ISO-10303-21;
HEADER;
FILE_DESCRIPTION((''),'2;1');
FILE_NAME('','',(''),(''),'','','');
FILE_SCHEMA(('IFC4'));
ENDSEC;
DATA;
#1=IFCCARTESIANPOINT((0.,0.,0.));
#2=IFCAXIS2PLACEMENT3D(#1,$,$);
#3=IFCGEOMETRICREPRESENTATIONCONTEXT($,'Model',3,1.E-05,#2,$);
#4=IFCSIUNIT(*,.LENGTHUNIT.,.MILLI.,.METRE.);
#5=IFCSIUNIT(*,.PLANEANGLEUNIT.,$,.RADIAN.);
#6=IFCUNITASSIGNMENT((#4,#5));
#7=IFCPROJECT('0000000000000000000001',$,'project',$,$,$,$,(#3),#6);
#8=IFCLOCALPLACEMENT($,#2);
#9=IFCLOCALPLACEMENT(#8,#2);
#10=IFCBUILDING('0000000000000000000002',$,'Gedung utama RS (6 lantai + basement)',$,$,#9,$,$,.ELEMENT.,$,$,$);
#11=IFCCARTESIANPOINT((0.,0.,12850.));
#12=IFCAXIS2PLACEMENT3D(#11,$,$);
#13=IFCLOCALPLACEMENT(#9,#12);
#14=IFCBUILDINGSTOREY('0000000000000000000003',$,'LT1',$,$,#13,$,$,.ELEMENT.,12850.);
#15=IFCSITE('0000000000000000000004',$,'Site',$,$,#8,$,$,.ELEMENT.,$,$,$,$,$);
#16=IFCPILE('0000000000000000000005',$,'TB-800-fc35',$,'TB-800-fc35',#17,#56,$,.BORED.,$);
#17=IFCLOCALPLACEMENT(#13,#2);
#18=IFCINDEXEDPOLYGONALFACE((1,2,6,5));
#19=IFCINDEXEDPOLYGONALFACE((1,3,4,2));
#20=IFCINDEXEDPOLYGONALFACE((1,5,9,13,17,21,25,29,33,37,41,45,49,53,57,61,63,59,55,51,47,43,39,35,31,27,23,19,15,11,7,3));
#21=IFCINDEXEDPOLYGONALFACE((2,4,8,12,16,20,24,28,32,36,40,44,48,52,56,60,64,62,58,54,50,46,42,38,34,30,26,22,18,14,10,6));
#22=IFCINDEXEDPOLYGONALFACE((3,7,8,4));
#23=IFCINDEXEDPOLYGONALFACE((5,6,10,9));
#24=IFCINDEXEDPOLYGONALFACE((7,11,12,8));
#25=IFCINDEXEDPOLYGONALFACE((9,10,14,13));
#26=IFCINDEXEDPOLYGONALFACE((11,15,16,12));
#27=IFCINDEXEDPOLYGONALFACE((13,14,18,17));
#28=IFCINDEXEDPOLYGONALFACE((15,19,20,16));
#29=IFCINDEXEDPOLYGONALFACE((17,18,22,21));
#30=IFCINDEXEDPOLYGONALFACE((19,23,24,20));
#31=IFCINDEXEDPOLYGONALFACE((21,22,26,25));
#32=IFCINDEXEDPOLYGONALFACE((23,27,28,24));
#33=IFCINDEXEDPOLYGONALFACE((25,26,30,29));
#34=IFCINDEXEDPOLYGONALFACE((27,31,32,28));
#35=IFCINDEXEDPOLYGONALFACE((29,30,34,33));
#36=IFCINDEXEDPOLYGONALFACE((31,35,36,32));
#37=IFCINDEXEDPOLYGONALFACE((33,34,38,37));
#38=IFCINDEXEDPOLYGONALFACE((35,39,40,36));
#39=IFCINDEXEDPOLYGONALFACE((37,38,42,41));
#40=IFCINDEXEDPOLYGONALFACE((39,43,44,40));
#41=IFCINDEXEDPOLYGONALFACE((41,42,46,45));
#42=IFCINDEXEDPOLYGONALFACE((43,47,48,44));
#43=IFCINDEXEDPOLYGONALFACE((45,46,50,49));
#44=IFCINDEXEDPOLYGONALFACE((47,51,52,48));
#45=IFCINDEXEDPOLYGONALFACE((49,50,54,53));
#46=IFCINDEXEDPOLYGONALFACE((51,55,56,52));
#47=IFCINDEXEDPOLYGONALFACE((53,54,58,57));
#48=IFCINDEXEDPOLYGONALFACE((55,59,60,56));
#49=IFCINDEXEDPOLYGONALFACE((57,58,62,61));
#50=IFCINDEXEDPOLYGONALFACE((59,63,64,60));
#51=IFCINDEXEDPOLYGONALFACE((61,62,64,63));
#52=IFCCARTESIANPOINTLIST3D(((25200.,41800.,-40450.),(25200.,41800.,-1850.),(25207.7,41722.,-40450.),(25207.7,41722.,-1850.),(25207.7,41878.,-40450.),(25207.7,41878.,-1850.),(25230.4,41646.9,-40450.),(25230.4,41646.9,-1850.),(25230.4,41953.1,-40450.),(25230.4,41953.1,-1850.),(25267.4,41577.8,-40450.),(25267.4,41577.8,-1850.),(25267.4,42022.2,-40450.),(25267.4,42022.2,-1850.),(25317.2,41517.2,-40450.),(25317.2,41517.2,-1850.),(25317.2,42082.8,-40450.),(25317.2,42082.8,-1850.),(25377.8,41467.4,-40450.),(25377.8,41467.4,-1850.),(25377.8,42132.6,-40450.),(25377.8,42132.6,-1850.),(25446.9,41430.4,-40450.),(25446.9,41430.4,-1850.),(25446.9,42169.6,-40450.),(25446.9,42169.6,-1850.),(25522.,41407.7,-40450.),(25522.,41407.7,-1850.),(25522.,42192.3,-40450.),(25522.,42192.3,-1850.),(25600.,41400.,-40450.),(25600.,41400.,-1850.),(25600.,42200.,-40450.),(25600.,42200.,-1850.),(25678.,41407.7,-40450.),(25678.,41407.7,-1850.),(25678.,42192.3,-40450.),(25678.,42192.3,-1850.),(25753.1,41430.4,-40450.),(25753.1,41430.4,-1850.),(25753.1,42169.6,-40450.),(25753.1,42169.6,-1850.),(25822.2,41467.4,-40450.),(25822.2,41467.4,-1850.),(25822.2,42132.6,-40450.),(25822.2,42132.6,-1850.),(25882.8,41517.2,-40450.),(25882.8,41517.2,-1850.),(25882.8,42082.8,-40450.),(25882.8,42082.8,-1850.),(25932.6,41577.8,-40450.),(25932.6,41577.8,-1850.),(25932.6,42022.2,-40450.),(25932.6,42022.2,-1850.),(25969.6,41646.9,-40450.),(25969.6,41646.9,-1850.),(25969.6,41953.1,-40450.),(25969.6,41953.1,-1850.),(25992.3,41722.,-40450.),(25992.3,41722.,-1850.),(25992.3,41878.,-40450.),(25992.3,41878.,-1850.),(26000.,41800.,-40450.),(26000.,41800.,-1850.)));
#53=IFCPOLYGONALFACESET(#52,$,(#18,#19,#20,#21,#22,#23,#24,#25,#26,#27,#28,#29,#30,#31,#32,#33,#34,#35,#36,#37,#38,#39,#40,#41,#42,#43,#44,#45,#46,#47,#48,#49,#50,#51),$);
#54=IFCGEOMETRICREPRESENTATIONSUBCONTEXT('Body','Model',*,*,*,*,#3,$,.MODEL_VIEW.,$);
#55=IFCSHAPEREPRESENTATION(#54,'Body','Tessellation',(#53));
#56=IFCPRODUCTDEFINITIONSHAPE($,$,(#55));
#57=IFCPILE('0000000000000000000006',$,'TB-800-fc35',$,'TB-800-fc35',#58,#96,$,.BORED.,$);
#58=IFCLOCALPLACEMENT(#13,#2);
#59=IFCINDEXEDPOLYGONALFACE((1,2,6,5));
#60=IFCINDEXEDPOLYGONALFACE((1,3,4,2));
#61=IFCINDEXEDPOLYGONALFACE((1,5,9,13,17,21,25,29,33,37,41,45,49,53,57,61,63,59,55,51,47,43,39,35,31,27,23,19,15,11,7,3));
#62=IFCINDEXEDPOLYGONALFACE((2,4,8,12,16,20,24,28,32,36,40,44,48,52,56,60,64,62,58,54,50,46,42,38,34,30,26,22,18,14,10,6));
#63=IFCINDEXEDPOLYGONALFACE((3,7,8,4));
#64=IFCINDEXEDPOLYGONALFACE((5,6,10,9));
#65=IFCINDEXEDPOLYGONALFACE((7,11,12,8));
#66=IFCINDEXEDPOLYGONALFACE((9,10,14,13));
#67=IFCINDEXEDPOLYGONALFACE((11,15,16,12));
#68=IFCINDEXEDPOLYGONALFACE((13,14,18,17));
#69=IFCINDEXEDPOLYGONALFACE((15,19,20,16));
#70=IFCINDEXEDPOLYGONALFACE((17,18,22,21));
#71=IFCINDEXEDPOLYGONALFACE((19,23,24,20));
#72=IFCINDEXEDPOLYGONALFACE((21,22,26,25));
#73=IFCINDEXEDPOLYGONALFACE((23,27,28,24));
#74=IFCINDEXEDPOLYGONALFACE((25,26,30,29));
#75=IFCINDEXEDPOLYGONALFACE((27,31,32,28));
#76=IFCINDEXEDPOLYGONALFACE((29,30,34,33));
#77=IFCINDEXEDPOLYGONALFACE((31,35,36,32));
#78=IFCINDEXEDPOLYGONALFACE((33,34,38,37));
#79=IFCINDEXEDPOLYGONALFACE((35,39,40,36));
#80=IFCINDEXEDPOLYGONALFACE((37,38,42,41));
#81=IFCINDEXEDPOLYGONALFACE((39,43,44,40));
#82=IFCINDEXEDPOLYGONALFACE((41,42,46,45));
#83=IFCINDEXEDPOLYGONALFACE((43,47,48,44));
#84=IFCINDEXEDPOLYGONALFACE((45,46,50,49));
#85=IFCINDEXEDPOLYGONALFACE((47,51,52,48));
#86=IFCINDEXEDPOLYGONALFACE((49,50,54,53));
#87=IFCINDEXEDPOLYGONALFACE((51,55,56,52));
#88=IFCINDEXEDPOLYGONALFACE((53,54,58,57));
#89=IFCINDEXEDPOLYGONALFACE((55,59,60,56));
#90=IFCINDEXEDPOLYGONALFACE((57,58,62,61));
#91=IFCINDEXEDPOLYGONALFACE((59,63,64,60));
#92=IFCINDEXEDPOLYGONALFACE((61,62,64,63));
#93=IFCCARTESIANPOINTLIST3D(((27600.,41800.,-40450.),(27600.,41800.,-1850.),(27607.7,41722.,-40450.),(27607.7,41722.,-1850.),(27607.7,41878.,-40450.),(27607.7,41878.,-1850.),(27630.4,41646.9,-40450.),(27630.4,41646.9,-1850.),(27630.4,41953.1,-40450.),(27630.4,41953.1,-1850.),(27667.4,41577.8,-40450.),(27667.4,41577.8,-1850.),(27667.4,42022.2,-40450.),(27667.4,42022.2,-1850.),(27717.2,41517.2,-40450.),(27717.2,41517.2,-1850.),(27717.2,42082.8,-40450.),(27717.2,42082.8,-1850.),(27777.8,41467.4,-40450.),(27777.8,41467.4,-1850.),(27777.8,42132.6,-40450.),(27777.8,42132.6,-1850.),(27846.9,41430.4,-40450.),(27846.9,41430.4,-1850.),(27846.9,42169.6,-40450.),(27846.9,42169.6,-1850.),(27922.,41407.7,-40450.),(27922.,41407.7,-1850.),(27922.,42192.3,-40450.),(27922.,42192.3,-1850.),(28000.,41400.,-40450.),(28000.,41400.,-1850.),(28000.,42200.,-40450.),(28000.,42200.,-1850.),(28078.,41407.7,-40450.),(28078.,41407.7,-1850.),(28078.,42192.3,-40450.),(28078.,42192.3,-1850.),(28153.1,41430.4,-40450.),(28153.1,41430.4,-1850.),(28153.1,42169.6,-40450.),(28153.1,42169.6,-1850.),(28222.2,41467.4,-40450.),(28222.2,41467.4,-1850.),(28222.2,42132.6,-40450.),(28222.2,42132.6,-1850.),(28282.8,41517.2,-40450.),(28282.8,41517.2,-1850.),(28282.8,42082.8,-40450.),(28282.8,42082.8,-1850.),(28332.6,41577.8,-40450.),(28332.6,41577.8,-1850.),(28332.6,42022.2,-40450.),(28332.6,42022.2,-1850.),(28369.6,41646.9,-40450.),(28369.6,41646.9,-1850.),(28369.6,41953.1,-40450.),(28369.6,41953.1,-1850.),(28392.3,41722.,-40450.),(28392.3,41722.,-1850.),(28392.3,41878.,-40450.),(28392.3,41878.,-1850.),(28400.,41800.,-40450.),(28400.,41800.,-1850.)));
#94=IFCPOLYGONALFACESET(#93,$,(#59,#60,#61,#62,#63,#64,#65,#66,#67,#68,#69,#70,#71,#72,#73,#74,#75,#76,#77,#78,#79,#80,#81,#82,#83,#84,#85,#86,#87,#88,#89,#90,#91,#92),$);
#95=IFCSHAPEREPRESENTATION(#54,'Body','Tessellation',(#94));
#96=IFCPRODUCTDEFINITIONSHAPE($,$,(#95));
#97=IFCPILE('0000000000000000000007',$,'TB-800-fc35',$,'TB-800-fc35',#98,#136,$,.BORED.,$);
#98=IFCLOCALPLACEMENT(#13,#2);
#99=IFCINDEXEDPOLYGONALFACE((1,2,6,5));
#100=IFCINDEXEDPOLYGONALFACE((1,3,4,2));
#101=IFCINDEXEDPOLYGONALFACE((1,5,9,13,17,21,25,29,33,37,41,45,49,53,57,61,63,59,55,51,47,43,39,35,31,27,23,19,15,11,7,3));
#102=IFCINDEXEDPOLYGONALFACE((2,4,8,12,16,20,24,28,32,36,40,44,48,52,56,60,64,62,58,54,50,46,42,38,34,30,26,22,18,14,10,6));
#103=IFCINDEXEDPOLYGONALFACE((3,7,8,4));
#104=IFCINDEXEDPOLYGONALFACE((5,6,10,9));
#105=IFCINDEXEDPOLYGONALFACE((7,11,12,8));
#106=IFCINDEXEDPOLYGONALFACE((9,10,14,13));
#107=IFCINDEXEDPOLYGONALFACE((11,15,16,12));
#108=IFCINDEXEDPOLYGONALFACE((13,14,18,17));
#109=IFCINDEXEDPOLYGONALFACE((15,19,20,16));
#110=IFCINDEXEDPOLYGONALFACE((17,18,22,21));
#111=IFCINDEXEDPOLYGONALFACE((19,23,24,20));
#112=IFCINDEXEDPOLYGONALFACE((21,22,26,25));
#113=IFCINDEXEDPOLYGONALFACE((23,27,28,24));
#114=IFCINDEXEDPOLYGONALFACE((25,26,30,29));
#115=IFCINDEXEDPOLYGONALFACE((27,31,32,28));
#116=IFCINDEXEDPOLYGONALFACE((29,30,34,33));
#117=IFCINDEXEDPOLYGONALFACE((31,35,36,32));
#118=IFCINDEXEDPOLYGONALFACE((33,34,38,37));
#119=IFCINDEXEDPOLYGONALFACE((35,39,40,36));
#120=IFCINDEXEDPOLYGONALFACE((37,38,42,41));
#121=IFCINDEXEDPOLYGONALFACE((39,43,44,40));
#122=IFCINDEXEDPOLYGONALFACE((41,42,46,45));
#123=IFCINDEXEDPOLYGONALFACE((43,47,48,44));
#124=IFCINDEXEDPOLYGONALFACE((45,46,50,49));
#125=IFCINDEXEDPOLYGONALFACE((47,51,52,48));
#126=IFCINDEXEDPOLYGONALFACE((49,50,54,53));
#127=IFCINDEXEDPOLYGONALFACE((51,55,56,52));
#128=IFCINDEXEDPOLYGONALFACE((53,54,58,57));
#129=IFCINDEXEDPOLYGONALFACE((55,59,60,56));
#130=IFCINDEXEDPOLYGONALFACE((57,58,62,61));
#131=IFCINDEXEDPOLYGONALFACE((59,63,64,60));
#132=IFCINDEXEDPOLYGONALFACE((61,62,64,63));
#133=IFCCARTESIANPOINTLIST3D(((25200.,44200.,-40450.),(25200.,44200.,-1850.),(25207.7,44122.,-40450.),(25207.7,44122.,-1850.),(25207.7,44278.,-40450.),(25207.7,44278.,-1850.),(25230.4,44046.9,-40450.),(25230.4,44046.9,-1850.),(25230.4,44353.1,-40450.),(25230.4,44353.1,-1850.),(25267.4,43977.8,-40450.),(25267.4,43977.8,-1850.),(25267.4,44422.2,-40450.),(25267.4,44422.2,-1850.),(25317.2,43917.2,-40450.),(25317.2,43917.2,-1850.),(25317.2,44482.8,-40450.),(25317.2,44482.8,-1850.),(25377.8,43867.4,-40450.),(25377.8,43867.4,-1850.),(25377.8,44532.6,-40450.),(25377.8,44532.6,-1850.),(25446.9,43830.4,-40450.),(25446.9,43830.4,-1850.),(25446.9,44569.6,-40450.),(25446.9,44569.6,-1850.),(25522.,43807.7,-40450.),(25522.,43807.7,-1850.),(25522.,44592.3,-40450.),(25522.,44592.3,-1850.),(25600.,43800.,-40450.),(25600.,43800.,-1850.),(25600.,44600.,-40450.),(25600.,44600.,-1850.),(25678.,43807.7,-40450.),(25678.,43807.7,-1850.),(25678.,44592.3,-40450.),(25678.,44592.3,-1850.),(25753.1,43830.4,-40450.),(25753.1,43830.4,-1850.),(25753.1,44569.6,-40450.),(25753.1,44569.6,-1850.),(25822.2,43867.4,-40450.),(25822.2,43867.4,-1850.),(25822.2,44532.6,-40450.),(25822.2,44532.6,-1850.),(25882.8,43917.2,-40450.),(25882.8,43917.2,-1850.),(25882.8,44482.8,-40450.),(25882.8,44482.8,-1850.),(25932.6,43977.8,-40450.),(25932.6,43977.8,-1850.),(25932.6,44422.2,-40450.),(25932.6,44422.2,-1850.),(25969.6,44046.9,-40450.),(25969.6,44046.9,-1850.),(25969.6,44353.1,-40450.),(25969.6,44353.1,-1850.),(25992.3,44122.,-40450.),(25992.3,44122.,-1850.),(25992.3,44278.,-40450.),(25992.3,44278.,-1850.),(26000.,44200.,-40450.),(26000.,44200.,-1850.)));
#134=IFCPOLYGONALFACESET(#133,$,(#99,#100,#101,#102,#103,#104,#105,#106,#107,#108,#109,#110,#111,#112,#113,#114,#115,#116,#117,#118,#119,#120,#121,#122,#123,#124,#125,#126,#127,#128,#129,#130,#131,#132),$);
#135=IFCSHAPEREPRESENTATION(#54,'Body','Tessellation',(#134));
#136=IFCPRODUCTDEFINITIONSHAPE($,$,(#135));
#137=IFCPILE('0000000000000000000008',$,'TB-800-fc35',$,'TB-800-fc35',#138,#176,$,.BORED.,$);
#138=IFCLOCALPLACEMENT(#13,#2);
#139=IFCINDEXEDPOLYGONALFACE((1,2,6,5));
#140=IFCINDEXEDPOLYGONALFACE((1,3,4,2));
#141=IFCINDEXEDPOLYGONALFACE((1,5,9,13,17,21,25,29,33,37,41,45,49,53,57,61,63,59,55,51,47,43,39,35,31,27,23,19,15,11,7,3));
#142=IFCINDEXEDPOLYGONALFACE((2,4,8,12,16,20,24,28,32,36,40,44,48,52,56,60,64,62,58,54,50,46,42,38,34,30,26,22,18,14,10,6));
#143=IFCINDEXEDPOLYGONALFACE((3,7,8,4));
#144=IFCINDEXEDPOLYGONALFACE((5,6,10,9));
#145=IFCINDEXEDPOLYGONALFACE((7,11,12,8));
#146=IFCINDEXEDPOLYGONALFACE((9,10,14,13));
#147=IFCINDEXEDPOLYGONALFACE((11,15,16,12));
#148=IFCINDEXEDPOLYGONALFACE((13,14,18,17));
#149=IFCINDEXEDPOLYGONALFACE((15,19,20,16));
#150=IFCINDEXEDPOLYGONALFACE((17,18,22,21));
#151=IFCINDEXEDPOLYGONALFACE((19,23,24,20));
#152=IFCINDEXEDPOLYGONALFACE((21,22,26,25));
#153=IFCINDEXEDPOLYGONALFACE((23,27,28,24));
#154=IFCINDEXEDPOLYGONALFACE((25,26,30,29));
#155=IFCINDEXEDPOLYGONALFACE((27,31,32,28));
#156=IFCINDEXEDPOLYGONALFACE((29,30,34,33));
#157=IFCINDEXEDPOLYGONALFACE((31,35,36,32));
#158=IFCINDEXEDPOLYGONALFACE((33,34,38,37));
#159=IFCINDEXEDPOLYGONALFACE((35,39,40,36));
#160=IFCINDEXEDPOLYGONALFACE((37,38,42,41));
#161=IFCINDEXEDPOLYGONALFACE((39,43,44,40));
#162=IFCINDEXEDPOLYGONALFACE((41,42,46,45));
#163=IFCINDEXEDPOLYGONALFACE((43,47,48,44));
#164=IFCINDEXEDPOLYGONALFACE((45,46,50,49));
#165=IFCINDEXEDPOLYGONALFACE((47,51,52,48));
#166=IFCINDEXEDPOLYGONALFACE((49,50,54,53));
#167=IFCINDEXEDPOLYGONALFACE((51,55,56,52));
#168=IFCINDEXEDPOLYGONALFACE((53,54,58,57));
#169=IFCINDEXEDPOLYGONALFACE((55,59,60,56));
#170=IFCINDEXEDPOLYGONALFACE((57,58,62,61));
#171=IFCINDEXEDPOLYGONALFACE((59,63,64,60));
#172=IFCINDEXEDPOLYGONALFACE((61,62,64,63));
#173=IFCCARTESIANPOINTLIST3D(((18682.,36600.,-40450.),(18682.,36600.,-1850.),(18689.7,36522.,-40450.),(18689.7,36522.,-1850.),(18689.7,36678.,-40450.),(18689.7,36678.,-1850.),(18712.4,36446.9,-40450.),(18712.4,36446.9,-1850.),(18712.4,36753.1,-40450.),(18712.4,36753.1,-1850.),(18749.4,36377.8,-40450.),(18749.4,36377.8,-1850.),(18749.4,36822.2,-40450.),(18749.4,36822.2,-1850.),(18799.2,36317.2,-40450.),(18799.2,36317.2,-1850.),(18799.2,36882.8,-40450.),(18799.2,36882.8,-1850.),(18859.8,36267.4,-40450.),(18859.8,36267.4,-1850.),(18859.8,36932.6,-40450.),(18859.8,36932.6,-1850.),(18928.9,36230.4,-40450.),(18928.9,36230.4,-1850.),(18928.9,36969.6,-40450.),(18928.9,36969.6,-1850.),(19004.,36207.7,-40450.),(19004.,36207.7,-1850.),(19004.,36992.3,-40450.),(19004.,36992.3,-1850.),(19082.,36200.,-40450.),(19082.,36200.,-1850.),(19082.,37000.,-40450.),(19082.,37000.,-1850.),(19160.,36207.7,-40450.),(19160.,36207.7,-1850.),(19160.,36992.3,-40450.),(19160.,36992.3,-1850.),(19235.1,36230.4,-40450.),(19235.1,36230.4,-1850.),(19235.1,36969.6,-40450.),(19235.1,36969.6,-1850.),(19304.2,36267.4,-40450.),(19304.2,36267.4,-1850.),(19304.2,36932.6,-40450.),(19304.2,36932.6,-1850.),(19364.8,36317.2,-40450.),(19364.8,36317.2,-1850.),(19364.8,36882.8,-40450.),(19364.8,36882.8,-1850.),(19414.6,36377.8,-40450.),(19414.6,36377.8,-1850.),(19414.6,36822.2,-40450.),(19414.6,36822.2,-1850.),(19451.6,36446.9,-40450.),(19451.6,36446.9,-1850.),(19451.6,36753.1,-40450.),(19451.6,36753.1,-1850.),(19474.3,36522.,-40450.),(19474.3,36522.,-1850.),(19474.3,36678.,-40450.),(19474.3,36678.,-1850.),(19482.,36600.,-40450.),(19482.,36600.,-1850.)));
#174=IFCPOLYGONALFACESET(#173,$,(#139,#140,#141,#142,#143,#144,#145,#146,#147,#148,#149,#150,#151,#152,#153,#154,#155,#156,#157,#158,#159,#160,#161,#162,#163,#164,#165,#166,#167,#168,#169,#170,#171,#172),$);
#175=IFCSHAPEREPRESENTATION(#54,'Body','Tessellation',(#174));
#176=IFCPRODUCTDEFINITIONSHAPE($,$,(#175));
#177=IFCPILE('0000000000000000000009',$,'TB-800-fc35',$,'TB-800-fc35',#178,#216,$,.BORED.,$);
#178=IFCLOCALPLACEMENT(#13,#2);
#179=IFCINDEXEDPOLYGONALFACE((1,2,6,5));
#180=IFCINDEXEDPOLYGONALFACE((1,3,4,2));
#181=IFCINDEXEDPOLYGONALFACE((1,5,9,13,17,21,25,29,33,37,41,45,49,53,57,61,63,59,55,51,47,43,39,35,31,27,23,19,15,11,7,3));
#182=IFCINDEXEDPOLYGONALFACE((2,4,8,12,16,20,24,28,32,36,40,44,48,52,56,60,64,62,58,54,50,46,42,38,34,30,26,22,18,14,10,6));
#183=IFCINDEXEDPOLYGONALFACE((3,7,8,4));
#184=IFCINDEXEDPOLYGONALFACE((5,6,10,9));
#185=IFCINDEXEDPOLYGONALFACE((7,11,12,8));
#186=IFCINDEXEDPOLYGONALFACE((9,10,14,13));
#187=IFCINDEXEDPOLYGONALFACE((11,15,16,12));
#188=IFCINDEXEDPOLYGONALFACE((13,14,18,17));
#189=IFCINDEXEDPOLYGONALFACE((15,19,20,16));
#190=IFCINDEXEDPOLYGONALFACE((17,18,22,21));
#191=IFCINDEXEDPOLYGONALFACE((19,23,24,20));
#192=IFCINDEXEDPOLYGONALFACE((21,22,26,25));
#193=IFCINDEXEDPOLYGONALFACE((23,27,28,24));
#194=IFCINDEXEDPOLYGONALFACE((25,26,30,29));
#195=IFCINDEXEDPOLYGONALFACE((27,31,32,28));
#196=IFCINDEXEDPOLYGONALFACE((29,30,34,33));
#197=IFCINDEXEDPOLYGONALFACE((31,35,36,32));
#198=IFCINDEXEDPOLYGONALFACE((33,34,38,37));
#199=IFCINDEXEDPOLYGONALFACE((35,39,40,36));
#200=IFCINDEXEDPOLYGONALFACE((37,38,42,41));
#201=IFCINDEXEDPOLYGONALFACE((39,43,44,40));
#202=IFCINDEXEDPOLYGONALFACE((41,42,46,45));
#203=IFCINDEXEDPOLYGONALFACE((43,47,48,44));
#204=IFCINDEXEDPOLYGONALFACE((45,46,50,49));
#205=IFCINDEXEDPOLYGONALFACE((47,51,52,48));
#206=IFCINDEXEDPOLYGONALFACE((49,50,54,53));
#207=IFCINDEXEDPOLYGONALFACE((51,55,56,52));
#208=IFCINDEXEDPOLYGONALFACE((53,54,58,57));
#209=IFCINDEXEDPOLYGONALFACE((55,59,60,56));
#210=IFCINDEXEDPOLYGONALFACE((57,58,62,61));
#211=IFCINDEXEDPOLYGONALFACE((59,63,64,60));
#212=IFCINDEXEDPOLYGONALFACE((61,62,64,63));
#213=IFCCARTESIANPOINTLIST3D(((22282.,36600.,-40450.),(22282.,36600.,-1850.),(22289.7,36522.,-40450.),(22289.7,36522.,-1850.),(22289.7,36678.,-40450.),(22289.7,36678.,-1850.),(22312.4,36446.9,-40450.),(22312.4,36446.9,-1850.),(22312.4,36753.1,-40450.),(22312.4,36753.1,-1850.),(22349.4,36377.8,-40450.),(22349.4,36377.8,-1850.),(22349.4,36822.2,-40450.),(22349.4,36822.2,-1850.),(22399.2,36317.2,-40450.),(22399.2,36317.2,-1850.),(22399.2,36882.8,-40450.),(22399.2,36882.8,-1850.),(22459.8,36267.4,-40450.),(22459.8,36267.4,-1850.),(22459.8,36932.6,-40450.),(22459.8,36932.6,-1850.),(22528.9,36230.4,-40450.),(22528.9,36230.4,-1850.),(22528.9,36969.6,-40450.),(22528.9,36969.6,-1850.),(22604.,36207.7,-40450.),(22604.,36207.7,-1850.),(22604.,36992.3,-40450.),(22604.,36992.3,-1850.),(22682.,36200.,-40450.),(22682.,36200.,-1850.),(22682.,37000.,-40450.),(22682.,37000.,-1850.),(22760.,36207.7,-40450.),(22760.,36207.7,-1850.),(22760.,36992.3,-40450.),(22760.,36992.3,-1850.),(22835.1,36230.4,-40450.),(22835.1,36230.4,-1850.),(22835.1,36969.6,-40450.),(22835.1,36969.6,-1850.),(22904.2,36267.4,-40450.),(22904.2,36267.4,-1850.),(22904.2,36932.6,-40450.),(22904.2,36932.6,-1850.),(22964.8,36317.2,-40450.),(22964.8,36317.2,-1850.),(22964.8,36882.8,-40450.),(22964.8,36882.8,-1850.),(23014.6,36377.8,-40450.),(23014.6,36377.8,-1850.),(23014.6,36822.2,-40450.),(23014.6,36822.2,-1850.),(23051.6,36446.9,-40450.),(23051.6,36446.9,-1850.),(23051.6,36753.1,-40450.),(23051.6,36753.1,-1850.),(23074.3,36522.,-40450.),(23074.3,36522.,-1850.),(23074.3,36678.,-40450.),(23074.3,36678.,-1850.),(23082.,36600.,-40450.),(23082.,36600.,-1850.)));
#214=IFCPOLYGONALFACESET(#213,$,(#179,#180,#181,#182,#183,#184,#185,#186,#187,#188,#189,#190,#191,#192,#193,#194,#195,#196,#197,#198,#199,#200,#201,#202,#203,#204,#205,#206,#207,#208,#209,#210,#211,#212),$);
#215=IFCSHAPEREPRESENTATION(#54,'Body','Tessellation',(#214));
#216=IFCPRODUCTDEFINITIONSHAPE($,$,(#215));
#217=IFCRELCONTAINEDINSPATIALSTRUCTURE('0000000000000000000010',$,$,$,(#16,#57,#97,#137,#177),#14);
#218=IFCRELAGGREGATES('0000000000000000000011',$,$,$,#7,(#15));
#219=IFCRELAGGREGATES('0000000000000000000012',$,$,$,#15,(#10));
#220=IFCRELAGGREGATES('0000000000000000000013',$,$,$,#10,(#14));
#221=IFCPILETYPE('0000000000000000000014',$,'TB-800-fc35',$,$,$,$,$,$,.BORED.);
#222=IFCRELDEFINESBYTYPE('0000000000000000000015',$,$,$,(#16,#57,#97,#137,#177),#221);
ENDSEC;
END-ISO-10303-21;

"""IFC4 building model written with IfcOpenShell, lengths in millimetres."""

from ifc_helpers import new_model, si_unit, frame, origin, origin_2d, place, context, subcontext, project, spatial, circle, extrude, material_profile, profile_set, profile_usage, type_object, element, save


model = new_model("IFC4")

# Units and contexts
model_context = context("Model", 3, precision=1e-05, world=origin())
body_context = subcontext(model_context, "Body", "Model", "MODEL_VIEW")
ifc_project = project(units=[si_unit("LENGTHUNIT", "METRE", prefix="MILLI"), si_unit("PLANEANGLEUNIT", "RADIAN")], contexts=[model_context])

# Site, building, storey
site_placement = place(None, origin())
site = spatial("IfcSite", under=ifc_project, at=site_placement, Name="Site", CompositionType="ELEMENT")
building_placement = place(site_placement, origin())
building = spatial("IfcBuilding", under=site, at=building_placement, Name="Gedung utama RS (6 lantai + basement)", CompositionType="ELEMENT")
storey_placement = place(building_placement, frame((0.0, 0.0, 12850.0)))
storey = spatial("IfcBuildingStorey", under=building, at=storey_placement, Name="LT1", CompositionType="ELEMENT", Elevation=12850.0)

# Piles
ifc_material_profile_1 = material_profile(None, circle(Radius=400.0, at=origin_2d()), Name="TB-800-fc35")
ifc_profile_set_1 = profile_set([ifc_material_profile_1], Name="TB-800-fc35")
ifc_profile_usage_1 = profile_usage(ifc_profile_set_1, cardinal=5)
pile_type = type_object("IfcPileType", Name="TB-800-fc35", PredefinedType="BORED", material=ifc_profile_set_1)
for number, where, z_axis, x_axis, name in (
    (1, (25600.0, 41800.0, -40450.0), (0.0, 0.0, 1.0), (1.0, 0.0, 0.0), "TB-800-fc35"),
    (2, (28000.0, 41800.0, -40450.0), (0.0, 0.0, 1.0), (1.0, 0.0, 0.0), "TB-800-fc35"),
    (3, (25600.0, 44200.0, -40450.0), (0.0, 0.0, 1.0), (1.0, 0.0, 0.0), "TB-800-fc35"),
    (4, (19082.0, 36600.0, -40450.0), (0.0, 0.0, 1.0), (1.0, 0.0, 0.0), "TB-800-fc35"),
    (5, (22682.0, 36600.0, -40450.0), (0.0, 0.0, 1.0), (1.0, 0.0, 0.0), "TB-800-fc35"),
):
    element("IfcPile", number, at=place(storey_placement, frame(where, z_axis=z_axis, x_axis=x_axis)), inside=storey, type_object=pile_type, material=ifc_profile_usage_1, Name=name, ObjectType="TB-800-fc35", PredefinedType="BORED", context=body_context, shape_type="SweptSolid", body=[
        extrude(circle(Radius=400.0, at=origin_2d()), origin(), (0.0, 0.0, 1.0), 38600.0),
    ])

save(model, "model.ifc")
